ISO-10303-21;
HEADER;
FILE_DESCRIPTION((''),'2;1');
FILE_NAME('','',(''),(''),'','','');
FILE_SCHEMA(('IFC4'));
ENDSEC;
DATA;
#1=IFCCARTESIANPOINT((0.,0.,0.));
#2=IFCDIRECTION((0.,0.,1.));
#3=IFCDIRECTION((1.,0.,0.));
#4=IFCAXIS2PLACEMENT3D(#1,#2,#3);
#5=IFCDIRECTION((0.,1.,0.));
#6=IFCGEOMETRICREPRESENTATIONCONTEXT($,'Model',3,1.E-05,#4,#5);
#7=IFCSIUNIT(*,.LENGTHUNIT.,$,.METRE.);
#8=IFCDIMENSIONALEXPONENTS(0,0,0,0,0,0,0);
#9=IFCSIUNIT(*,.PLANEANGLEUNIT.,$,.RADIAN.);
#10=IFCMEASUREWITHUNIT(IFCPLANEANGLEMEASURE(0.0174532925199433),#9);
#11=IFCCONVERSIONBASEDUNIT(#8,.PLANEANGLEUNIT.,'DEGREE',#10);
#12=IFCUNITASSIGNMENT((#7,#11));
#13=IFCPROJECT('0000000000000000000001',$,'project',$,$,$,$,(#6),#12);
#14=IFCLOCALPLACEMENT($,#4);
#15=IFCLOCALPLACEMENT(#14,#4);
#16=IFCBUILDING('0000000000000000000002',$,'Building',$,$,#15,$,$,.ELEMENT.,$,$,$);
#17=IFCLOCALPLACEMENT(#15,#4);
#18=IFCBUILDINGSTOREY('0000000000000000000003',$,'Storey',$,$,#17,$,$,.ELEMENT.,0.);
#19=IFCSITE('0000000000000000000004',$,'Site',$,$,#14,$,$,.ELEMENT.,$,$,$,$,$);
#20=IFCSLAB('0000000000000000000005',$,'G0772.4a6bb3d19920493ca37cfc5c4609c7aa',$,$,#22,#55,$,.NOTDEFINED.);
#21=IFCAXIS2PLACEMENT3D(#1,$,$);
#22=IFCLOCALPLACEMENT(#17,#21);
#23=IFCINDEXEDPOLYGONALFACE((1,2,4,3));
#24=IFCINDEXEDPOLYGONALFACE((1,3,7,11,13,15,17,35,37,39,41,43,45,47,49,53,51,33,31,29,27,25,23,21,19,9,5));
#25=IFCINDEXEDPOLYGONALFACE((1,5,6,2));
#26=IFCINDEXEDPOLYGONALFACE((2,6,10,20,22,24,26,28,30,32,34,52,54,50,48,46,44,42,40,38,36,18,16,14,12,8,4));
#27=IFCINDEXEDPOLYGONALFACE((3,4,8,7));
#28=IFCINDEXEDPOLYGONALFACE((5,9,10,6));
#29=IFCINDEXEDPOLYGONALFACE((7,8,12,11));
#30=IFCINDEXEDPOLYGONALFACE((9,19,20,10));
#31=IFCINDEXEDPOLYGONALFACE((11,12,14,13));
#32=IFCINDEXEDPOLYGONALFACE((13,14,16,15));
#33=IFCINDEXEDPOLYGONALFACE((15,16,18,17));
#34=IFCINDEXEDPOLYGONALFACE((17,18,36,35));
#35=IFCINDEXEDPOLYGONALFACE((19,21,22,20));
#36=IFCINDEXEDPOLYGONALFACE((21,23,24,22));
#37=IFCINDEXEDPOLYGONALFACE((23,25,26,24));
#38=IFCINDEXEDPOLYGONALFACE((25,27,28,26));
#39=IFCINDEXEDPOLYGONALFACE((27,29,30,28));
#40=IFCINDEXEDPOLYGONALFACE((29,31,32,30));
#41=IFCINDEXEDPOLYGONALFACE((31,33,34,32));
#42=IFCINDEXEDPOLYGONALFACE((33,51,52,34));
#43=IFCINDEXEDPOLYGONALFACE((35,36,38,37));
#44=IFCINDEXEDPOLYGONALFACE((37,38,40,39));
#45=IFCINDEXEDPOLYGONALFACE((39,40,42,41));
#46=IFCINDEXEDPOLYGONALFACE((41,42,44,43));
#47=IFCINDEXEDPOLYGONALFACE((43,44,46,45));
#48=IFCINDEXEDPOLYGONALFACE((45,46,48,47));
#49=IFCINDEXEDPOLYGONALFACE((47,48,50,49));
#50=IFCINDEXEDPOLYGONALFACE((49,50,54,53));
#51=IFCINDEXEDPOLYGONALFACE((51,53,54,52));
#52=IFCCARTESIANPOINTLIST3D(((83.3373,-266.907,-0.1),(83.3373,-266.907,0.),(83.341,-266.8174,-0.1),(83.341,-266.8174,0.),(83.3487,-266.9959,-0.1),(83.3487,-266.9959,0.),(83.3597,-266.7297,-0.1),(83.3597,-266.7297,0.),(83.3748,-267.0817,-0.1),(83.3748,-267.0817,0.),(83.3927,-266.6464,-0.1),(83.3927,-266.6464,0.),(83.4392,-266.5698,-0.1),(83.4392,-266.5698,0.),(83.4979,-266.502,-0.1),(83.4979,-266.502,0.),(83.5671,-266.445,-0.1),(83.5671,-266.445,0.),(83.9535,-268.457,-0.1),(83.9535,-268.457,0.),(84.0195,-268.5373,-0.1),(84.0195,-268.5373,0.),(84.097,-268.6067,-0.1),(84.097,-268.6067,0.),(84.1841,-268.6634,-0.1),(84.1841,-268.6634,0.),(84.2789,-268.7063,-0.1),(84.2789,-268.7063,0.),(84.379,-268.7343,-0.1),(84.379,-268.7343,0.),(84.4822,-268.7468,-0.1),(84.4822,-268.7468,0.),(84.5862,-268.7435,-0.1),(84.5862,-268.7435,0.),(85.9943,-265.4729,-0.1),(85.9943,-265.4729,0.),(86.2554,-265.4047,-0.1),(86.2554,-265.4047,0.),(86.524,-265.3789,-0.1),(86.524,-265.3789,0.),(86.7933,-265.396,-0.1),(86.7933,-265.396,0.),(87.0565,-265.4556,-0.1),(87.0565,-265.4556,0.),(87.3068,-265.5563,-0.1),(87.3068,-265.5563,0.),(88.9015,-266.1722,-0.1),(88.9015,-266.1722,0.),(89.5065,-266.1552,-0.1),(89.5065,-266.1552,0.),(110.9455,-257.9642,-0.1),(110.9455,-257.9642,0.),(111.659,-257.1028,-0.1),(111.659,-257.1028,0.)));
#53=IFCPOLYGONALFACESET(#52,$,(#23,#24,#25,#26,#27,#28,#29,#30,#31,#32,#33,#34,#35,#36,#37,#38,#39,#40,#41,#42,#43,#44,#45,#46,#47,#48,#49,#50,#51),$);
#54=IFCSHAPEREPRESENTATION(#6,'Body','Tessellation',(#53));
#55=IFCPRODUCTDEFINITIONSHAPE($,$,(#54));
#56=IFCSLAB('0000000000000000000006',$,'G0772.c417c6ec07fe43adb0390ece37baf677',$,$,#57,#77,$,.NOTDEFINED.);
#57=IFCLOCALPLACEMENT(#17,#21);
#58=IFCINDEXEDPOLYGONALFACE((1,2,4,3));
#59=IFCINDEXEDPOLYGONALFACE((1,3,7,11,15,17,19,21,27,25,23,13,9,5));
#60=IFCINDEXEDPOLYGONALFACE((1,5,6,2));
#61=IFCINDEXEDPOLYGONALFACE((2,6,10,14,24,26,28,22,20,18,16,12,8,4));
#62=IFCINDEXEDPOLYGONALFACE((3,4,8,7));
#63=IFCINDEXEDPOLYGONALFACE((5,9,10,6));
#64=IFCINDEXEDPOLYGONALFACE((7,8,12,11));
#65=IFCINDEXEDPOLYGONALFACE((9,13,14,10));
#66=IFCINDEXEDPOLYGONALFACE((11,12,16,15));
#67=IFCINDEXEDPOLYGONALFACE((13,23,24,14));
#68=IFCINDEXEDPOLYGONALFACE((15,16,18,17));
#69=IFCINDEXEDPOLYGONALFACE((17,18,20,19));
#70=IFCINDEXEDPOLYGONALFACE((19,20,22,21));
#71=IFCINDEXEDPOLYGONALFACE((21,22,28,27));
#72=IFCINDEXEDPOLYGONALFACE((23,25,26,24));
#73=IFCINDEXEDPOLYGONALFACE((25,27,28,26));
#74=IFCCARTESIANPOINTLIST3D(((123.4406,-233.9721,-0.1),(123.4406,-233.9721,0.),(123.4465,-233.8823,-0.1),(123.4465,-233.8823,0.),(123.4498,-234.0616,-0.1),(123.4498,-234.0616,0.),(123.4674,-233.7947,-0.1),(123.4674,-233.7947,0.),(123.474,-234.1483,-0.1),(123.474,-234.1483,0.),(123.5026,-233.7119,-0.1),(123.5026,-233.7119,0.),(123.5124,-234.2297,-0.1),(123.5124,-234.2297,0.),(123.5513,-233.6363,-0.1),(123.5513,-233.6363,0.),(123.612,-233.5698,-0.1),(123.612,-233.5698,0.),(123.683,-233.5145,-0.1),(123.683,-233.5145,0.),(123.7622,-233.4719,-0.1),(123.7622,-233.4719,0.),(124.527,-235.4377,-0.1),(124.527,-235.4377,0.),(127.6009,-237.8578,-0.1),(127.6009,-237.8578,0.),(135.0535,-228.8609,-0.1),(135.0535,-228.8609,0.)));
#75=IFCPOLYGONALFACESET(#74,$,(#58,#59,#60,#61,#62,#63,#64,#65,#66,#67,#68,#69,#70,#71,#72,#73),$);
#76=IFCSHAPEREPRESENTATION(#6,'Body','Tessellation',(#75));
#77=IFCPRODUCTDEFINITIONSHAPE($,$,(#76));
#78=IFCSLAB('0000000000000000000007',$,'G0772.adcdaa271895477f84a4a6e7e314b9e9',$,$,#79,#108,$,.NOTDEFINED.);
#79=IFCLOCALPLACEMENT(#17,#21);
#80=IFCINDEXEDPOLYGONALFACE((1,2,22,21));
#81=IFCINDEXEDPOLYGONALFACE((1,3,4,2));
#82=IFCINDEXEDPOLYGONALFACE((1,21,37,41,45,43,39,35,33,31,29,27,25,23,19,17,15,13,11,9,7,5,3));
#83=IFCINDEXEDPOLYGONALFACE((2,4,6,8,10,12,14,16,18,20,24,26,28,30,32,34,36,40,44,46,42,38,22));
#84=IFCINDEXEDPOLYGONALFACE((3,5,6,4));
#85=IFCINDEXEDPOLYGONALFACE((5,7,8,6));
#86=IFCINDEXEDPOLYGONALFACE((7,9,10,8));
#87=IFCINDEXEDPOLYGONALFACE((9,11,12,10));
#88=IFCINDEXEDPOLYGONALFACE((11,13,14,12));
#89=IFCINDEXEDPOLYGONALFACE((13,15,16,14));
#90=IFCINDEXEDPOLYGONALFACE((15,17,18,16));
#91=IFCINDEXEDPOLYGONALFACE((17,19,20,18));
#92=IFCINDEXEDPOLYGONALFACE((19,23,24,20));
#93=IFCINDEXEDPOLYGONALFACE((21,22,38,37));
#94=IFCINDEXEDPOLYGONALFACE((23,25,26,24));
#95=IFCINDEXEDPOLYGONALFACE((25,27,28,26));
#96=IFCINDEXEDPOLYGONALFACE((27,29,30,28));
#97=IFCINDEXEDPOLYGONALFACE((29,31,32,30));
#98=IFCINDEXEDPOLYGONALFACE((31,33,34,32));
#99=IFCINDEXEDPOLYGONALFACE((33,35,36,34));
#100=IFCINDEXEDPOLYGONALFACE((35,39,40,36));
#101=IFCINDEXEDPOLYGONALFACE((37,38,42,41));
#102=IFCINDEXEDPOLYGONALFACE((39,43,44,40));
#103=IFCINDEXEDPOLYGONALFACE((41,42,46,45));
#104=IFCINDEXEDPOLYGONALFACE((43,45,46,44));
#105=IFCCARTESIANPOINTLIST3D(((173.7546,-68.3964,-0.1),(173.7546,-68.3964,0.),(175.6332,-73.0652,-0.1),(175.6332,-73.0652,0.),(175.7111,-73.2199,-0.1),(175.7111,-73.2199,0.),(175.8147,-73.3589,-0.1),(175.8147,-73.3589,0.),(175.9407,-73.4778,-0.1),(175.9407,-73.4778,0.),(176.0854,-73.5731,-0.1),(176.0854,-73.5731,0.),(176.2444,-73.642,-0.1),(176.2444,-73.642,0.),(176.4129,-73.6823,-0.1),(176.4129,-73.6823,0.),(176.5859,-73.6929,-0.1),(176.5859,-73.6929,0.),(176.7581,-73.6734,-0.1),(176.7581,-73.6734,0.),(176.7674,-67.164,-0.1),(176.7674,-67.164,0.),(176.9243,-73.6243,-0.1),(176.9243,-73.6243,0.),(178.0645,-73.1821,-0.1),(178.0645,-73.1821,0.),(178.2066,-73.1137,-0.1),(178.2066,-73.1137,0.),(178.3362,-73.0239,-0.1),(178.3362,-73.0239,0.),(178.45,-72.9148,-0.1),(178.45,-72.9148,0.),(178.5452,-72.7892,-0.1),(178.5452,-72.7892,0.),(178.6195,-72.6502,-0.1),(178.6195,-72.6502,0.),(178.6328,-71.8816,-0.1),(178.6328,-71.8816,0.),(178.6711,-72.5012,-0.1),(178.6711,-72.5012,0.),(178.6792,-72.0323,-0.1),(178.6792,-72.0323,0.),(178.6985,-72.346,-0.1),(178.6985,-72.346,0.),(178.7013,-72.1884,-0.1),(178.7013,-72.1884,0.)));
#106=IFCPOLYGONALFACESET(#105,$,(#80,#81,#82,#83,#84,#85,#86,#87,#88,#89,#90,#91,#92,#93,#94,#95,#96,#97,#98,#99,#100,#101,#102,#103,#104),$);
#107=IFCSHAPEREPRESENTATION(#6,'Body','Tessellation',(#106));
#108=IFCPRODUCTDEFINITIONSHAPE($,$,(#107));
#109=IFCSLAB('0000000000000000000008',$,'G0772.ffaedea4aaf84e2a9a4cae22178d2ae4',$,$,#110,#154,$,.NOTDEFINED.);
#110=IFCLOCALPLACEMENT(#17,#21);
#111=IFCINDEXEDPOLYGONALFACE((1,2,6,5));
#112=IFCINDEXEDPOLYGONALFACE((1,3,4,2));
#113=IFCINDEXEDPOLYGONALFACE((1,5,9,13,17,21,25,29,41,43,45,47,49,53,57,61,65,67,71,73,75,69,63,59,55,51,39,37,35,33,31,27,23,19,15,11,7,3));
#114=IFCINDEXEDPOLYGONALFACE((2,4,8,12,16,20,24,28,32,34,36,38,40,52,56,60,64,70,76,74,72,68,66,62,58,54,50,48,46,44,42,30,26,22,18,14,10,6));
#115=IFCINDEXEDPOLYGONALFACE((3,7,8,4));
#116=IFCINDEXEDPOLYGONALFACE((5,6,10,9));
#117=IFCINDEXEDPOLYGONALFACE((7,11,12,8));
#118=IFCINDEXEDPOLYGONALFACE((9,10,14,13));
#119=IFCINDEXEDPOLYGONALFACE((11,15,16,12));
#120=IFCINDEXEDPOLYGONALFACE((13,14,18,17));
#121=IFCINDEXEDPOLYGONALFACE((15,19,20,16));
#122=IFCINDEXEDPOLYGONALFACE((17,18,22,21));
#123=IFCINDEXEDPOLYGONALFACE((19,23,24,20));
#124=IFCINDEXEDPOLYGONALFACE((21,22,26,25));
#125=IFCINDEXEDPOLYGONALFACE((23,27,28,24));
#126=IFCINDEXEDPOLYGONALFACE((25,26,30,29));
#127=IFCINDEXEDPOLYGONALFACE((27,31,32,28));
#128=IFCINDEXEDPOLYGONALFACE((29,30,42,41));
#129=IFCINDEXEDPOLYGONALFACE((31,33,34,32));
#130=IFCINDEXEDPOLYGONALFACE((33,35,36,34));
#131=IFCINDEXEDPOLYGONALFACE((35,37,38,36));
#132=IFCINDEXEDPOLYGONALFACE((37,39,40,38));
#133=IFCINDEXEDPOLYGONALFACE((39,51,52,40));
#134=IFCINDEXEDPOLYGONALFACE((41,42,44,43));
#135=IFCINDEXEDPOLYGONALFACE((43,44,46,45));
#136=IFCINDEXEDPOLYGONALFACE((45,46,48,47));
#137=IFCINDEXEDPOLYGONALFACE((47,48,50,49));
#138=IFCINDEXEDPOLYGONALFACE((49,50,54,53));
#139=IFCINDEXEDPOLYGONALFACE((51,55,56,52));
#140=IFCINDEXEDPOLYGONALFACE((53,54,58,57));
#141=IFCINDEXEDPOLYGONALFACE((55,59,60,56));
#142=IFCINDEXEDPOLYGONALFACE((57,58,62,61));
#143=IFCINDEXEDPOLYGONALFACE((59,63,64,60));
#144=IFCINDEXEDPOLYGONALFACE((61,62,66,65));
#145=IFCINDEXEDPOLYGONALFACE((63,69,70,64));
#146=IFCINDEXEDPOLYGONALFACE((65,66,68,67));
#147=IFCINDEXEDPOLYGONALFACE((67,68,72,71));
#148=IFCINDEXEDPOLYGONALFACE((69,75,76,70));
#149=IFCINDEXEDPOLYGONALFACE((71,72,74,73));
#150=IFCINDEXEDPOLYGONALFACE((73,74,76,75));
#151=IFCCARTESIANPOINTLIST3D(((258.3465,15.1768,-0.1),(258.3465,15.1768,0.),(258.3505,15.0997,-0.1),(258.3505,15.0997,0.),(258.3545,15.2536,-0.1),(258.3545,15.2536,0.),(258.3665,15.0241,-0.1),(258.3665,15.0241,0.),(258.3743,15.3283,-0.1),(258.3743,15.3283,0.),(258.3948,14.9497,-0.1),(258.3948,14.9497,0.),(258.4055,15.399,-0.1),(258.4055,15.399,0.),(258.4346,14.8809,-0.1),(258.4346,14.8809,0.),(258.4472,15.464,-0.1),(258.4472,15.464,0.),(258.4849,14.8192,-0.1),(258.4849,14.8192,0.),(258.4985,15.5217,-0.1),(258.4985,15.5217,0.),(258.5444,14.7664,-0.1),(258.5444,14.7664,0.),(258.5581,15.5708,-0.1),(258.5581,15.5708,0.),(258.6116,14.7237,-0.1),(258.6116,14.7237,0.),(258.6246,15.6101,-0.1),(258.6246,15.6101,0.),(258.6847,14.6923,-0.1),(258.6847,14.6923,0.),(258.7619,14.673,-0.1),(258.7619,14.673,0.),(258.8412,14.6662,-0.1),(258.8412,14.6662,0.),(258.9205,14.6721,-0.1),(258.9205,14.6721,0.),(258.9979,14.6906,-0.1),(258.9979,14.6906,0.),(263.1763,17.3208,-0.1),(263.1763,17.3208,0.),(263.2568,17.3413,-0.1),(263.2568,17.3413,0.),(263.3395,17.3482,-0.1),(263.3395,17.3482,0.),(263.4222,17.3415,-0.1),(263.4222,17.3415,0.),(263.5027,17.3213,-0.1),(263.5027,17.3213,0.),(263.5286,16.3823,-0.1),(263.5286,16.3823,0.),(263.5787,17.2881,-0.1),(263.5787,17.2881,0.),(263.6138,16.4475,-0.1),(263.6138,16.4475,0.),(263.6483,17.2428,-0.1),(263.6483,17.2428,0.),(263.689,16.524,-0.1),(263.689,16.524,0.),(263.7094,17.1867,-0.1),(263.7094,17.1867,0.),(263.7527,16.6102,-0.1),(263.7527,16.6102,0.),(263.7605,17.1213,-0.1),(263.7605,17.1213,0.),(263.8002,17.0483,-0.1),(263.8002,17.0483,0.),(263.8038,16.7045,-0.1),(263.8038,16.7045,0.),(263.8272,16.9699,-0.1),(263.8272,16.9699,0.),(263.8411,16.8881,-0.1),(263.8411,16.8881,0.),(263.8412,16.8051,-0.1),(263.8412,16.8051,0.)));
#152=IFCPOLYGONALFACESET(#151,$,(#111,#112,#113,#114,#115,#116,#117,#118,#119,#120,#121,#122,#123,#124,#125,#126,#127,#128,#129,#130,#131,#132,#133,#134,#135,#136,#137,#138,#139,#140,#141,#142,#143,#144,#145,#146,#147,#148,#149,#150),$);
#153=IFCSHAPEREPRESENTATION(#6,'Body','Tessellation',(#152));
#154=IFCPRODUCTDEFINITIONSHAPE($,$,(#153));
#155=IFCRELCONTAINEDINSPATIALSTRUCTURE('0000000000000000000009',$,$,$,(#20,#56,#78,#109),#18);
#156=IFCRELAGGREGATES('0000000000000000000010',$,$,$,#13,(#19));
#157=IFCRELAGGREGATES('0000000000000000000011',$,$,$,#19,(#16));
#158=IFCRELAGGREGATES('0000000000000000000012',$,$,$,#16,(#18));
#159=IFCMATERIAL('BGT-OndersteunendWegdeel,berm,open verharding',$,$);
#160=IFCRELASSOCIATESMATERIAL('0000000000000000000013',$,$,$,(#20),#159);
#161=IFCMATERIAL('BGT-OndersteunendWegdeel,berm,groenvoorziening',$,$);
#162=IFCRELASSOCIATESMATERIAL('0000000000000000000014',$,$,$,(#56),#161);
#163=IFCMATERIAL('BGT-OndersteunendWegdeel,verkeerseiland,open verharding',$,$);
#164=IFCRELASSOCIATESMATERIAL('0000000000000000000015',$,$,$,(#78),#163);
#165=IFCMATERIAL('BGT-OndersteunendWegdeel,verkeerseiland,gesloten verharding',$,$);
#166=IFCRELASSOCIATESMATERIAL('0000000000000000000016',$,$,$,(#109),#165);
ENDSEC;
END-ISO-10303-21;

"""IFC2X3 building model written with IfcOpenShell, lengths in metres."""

from ifc_helpers import new_model, entity, si_unit, converted_unit, direction, frame, origin_with_axes, place, context, project, spatial, polyline, outline, extrude, material, element, save


model = new_model("IFC2X3")

# Units and contexts
model_context = context("Model", 3, precision=1e-05, world=origin_with_axes(), true_north=direction((0.0, 1.0, 0.0)))
ifc_project = project(units=[si_unit("LENGTHUNIT", "METRE"), converted_unit("PLANEANGLEUNIT", "DEGREE", entity("IfcPlaneAngleMeasure", 0.0174532925199433), si_unit("PLANEANGLEUNIT", "RADIAN"), dimensions=[0, 0, 0, 0, 0, 0, 0])], contexts=[model_context])

# Site, building, storey
site_placement = place(None, origin_with_axes())
site = spatial("IfcSite", under=ifc_project, at=site_placement, Name="Site", CompositionType="ELEMENT")
building_placement = place(site_placement, origin_with_axes())
building = spatial("IfcBuilding", under=site, at=building_placement, Name="Building", CompositionType="ELEMENT")
storey_placement = place(building_placement, origin_with_axes())
storey = spatial("IfcBuildingStorey", under=building, at=storey_placement, Name="Storey", CompositionType="ELEMENT", Elevation=0.0)

# Slabs
ifc_material_1 = material(Name="BGT-OndersteunendWegdeel,berm,open verharding")
slab_1_placement = place(storey_placement, frame((0.0, 0.0, -0.1), z_axis=(0.0, 0.0, 1.0), x_axis=(1.0, 0.0, 0.0)))
element("IfcSlab", 1, at=slab_1_placement, inside=storey, material=ifc_material_1, Name="G0772.4a6bb3d19920493ca37cfc5c4609c7aa", PredefinedType="NOTDEFINED", context=model_context, shape_type="SweptSolid", body=[
    extrude(outline(polyline([(84.5862, -268.7435), (84.4822, -268.7468), (84.379, -268.7343), (84.2789, -268.7063), (84.1841, -268.6634), (84.097, -268.6067), (84.0195, -268.5373), (83.9535, -268.457), (83.3748, -267.0817), (83.3487, -266.9959), (83.3373, -266.907), (83.341, -266.8174), (83.3597, -266.7297), (83.3927, -266.6464), (83.4392, -266.5698), (83.4979, -266.502), (83.5671, -266.445), (85.9943, -265.4729), (86.2554, -265.4047), (86.524, -265.3789), (86.7933, -265.396), (87.0565, -265.4556), (87.3068, -265.5563), (88.9015, -266.1722), (89.5065, -266.1552), (111.659, -257.1028), (110.9455, -257.9642), (84.5862, -268.7435)])), origin_with_axes(), (0.0, 0.0, 1.0), 0.1),
])
ifc_material_2 = material(Name="BGT-OndersteunendWegdeel,berm,groenvoorziening")
slab_2_placement = place(storey_placement, frame((0.0, 0.0, -0.1), z_axis=(0.0, 0.0, 1.0), x_axis=(1.0, 0.0, 0.0)))
element("IfcSlab", 2, at=slab_2_placement, inside=storey, material=ifc_material_2, Name="G0772.c417c6ec07fe43adb0390ece37baf677", PredefinedType="NOTDEFINED", context=model_context, shape_type="SweptSolid", body=[
    extrude(outline(polyline([(124.527, -235.4377), (123.5124, -234.2297), (123.474, -234.1483), (123.4498, -234.0616), (123.4406, -233.9721), (123.4465, -233.8823), (123.4674, -233.7947), (123.5026, -233.7119), (123.5513, -233.6363), (123.612, -233.5698), (123.683, -233.5145), (123.7622, -233.4719), (135.0535, -228.8609), (127.6009, -237.8578), (124.527, -235.4377)])), origin_with_axes(), (0.0, 0.0, 1.0), 0.1),
])
ifc_material_3 = material(Name="BGT-OndersteunendWegdeel,verkeerseiland,open verharding")
slab_3_placement = place(storey_placement, frame((0.0, 0.0, -0.1), z_axis=(0.0, 0.0, 1.0), x_axis=(1.0, 0.0, 0.0)))
element("IfcSlab", 3, at=slab_3_placement, inside=storey, material=ifc_material_3, Name="G0772.adcdaa271895477f84a4a6e7e314b9e9", PredefinedType="NOTDEFINED", context=model_context, shape_type="SweptSolid", body=[
    extrude(outline(polyline([(176.7581, -73.6734), (176.5859, -73.6929), (176.4129, -73.6823), (176.2444, -73.642), (176.0854, -73.5731), (175.9407, -73.4778), (175.8147, -73.3589), (175.7111, -73.2199), (175.6332, -73.0652), (173.7546, -68.3964), (176.7674, -67.164), (178.6328, -71.8816), (178.6792, -72.0323), (178.7013, -72.1884), (178.6985, -72.346), (178.6711, -72.5012), (178.6195, -72.6502), (178.5452, -72.7892), (178.45, -72.9148), (178.3362, -73.0239), (178.2066, -73.1137), (178.0645, -73.1821), (176.9243, -73.6243), (176.7581, -73.6734)])), origin_with_axes(), (0.0, 0.0, 1.0), 0.1),
])
ifc_material_4 = material(Name="BGT-OndersteunendWegdeel,verkeerseiland,gesloten verharding")
slab_4_placement = place(storey_placement, frame((0.0, 0.0, -0.1), z_axis=(0.0, 0.0, 1.0), x_axis=(1.0, 0.0, 0.0)))
element("IfcSlab", 4, at=slab_4_placement, inside=storey, material=ifc_material_4, Name="G0772.ffaedea4aaf84e2a9a4cae22178d2ae4", PredefinedType="NOTDEFINED", context=model_context, shape_type="SweptSolid", body=[
    extrude(outline(polyline([(263.8038, 16.7045), (263.7527, 16.6102), (263.689, 16.524), (263.6138, 16.4475), (263.5286, 16.3823), (258.9979, 14.6906), (258.9205, 14.6721), (258.8412, 14.6662), (258.7619, 14.673), (258.6847, 14.6923), (258.6116, 14.7237), (258.5444, 14.7664), (258.4849, 14.8192), (258.4346, 14.8809), (258.3948, 14.9497), (258.3665, 15.0241), (258.3505, 15.0997), (258.3465, 15.1768), (258.3545, 15.2536), (258.3743, 15.3283), (258.4055, 15.399), (258.4472, 15.464), (258.4985, 15.5217), (258.5581, 15.5708), (258.6246, 15.6101), (263.1763, 17.3208), (263.2568, 17.3413), (263.3395, 17.3482), (263.4222, 17.3415), (263.5027, 17.3213), (263.5787, 17.2881), (263.6483, 17.2428), (263.7094, 17.1867), (263.7605, 17.1213), (263.8002, 17.0483), (263.8272, 16.9699), (263.8411, 16.8881), (263.8412, 16.8051), (263.8038, 16.7045)])), origin_with_axes(), (0.0, 0.0, 1.0), 0.1),
])

save(model, "model.ifc")
